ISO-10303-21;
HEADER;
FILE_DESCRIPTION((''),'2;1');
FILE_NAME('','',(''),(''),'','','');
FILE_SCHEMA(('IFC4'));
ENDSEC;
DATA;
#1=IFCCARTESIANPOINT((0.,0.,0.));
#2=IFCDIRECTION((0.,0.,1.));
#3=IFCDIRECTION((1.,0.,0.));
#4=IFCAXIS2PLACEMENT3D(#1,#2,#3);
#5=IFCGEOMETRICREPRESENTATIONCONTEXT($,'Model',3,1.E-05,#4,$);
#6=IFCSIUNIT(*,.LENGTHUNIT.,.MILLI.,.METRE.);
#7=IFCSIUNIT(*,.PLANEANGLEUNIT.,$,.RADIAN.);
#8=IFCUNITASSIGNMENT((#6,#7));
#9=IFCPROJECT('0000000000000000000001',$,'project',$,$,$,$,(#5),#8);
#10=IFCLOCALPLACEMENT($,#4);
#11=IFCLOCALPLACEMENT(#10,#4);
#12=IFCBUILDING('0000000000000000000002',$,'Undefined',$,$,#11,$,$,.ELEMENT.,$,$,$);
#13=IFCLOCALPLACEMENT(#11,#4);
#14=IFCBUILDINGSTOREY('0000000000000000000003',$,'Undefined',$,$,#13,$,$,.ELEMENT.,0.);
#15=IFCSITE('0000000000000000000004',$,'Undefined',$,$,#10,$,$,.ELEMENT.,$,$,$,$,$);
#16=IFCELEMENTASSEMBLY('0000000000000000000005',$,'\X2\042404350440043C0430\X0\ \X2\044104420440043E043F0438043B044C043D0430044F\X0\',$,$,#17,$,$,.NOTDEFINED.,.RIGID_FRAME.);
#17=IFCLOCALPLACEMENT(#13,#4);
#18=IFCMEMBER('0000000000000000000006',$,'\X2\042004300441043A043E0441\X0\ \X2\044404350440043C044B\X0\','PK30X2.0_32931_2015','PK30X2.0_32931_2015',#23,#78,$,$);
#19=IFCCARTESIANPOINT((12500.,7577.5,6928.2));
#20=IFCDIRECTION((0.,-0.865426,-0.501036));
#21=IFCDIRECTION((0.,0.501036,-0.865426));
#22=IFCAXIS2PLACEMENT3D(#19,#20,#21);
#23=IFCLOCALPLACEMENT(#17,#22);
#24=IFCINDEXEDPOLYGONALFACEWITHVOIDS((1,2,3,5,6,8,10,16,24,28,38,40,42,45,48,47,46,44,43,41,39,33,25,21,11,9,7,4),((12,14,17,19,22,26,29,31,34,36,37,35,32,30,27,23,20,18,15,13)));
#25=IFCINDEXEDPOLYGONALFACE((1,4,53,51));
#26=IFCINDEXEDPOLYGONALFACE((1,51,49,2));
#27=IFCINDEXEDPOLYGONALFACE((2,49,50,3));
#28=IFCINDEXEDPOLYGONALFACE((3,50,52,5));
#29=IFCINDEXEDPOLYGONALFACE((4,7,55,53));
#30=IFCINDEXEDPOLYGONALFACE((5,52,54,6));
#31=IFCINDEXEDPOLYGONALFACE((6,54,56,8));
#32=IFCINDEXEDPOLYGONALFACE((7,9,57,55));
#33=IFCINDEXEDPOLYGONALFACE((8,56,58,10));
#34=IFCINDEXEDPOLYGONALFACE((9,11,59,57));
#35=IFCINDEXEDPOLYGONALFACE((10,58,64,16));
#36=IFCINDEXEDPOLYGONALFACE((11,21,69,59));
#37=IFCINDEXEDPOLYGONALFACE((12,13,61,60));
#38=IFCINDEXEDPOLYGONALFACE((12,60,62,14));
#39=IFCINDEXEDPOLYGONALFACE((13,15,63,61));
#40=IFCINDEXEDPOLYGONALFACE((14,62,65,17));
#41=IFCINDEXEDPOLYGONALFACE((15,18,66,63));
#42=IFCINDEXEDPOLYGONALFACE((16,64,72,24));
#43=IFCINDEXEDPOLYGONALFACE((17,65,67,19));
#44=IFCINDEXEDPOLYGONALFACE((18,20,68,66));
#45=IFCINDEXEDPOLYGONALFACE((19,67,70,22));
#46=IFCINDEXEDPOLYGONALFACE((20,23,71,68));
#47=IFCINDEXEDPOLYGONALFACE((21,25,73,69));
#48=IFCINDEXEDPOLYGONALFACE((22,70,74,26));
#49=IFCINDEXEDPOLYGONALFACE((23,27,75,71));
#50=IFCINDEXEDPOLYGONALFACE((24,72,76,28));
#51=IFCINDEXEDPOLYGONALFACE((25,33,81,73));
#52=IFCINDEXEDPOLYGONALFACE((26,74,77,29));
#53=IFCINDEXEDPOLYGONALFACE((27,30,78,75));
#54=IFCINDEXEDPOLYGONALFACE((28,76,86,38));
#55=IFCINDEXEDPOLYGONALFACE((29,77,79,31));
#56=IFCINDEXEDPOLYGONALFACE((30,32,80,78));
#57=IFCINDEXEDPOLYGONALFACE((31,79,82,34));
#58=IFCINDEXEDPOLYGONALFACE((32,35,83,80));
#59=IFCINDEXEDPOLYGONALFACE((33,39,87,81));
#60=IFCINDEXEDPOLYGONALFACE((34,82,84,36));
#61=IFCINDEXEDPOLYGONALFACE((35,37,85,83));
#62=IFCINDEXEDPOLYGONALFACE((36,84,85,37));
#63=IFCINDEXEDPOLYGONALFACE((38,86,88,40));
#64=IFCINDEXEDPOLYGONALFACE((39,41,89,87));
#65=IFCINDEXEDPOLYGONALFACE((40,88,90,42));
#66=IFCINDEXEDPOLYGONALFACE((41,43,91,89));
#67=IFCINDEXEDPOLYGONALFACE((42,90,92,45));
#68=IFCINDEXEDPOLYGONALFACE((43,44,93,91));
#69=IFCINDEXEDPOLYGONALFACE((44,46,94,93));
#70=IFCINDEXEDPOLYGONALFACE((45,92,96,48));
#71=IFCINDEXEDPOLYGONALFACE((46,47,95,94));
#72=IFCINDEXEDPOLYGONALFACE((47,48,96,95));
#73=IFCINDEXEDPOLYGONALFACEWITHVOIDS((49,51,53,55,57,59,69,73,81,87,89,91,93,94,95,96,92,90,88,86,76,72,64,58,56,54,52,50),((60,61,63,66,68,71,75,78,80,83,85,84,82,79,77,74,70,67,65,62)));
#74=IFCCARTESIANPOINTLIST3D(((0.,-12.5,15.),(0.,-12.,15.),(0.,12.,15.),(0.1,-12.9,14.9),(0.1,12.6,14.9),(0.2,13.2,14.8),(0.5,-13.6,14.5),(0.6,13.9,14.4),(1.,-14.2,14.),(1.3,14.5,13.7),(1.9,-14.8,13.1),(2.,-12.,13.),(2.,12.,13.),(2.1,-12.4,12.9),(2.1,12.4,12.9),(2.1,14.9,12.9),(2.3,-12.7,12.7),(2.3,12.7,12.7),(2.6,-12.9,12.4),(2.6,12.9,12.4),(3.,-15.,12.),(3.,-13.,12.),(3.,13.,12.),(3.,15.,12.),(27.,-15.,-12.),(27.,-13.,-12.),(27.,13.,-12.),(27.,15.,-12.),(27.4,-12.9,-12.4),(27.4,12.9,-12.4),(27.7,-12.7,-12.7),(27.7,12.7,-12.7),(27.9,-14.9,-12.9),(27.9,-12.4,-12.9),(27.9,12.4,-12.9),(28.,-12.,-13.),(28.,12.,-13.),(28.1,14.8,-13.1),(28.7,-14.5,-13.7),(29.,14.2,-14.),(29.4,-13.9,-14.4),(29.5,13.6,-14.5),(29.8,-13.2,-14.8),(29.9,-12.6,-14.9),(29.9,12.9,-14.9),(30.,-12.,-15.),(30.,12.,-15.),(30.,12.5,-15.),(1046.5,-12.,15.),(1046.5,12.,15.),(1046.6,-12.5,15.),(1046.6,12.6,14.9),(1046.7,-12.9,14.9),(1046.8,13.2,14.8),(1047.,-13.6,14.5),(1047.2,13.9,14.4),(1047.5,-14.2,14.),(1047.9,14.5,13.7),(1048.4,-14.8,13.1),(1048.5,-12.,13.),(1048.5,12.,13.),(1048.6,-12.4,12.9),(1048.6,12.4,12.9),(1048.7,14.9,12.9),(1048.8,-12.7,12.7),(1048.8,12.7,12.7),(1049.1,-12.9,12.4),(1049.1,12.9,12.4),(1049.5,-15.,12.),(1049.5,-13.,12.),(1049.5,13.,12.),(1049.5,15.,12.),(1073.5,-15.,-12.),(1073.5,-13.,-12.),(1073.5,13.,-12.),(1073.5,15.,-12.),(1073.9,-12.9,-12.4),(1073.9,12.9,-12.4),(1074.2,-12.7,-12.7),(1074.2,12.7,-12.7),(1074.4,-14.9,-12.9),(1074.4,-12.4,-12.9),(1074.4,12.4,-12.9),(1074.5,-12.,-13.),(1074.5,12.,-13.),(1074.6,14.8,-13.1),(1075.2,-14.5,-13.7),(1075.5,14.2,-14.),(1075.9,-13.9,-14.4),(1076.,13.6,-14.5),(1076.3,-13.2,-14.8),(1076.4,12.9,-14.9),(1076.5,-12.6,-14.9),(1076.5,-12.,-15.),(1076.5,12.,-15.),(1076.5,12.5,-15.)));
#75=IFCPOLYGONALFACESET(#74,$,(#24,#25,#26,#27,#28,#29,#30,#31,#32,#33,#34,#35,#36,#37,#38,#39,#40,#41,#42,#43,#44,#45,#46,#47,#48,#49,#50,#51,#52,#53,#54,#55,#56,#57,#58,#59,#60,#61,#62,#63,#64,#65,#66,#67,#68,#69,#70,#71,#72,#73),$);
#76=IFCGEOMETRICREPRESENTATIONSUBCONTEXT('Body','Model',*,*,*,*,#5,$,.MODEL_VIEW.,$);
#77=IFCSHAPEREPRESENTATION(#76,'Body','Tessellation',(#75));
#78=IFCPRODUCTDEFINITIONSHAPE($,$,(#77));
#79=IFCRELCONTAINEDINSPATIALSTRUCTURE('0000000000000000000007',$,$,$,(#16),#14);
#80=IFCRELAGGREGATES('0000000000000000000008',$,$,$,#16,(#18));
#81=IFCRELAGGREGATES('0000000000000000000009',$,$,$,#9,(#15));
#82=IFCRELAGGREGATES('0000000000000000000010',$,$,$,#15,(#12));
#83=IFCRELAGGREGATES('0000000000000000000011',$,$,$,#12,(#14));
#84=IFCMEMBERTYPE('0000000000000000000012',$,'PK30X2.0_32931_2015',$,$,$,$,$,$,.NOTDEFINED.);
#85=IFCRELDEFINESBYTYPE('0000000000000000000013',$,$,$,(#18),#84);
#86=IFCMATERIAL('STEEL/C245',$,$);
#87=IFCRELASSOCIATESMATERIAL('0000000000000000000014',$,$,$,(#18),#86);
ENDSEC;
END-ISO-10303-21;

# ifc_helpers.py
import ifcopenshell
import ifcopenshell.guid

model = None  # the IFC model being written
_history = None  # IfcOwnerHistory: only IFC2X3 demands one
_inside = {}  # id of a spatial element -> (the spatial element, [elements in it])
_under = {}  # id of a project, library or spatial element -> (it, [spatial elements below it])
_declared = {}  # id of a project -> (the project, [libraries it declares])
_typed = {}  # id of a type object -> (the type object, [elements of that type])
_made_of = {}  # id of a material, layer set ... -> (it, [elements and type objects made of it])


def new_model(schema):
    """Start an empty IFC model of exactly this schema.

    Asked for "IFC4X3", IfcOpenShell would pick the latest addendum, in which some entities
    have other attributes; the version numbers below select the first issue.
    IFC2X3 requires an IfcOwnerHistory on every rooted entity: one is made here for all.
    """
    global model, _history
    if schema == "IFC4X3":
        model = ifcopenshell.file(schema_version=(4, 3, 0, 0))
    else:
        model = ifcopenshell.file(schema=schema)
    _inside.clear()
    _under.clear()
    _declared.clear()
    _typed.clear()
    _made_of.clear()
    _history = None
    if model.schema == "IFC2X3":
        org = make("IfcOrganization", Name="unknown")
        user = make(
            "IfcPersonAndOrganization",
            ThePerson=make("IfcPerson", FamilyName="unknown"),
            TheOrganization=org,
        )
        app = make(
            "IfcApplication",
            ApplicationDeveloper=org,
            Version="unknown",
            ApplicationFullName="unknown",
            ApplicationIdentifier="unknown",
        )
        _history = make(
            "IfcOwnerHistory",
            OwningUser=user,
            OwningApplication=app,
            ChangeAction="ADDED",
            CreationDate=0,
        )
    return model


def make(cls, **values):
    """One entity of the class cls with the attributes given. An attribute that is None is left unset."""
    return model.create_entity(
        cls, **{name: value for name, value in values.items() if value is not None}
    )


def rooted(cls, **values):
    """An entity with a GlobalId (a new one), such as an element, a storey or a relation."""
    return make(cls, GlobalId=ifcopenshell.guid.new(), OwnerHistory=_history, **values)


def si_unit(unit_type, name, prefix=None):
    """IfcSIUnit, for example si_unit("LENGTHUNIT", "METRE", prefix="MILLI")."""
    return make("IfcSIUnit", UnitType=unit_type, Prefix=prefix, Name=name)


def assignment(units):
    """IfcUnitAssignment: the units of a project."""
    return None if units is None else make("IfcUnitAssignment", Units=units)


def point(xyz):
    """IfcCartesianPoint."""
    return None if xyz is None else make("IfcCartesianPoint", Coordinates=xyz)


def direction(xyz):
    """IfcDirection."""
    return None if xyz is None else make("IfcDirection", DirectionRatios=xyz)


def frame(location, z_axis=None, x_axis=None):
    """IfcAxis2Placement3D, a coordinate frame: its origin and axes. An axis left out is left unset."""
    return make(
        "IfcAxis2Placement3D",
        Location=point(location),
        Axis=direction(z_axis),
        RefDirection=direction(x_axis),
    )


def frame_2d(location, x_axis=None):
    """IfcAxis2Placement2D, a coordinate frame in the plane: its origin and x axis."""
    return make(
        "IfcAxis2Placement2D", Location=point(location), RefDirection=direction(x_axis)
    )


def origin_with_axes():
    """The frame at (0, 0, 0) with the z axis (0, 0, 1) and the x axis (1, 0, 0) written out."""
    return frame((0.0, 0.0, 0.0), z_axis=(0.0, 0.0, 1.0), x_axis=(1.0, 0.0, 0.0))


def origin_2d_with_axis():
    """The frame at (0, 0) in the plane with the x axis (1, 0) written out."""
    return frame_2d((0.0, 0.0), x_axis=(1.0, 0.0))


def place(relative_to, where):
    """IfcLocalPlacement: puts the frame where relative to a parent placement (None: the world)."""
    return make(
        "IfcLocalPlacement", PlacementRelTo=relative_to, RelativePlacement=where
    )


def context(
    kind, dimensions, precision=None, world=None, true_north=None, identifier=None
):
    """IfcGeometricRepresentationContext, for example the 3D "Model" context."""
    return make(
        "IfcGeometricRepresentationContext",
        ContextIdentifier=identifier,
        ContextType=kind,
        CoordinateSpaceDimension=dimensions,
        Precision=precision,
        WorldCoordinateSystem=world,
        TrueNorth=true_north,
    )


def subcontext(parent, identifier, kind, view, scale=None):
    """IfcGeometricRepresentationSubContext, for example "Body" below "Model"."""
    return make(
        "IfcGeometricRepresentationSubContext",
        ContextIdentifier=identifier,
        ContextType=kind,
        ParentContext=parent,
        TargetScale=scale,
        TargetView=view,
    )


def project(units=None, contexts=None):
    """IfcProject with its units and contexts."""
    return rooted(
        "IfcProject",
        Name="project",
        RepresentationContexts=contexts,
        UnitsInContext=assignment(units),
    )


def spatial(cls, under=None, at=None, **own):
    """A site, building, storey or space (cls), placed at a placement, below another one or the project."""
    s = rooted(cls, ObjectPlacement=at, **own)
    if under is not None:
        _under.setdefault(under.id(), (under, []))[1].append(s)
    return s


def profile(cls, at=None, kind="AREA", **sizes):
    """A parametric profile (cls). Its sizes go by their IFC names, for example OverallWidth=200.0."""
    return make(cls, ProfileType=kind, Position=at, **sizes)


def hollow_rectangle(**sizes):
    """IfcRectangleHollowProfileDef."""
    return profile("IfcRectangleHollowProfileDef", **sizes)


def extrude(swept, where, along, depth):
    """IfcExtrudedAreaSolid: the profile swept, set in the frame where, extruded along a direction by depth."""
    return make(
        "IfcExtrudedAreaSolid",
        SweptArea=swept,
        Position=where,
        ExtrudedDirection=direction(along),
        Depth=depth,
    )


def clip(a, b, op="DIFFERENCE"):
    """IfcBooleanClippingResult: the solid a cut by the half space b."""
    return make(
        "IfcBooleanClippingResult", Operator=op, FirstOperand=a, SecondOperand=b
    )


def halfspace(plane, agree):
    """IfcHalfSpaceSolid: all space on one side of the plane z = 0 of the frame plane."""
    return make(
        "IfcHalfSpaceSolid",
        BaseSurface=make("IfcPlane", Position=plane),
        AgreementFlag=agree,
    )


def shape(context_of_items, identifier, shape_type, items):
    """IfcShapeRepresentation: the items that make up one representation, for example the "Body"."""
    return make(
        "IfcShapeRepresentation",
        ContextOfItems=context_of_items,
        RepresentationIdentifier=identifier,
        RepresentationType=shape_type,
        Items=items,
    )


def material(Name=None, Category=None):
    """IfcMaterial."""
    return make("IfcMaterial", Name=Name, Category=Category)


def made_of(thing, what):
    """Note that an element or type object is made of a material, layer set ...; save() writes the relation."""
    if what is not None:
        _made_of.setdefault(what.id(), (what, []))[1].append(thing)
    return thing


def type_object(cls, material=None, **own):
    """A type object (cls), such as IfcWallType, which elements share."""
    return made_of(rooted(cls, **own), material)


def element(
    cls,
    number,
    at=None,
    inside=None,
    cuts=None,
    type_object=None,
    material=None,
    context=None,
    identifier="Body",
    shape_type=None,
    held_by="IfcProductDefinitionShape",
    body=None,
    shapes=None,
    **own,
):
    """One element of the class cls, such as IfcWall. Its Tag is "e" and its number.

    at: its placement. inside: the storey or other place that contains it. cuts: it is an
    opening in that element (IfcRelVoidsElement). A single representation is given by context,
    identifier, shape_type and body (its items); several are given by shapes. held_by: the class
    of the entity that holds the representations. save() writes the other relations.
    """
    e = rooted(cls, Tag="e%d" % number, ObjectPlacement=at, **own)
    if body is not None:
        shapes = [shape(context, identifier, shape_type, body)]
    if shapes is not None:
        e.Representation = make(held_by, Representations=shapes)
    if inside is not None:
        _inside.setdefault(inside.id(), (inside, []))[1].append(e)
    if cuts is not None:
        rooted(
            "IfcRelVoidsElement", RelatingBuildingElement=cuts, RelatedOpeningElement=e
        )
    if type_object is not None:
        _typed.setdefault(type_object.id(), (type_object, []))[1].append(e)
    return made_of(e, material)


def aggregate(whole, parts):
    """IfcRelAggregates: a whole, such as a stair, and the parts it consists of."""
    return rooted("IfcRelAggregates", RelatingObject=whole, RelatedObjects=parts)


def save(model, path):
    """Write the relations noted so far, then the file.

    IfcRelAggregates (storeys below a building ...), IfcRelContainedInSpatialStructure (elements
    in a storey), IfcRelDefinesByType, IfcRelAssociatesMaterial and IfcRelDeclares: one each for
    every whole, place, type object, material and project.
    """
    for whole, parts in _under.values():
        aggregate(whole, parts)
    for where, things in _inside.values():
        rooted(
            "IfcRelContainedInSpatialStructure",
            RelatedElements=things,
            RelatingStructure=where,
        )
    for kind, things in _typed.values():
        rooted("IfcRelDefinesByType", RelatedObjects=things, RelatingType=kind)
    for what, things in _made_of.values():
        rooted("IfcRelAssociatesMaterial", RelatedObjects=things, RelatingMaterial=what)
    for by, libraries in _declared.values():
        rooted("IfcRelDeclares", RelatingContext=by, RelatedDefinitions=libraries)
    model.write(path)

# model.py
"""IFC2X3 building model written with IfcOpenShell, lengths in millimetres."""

from ifc_helpers import new_model, si_unit, frame, origin_with_axes, origin_2d_with_axis, place, context, subcontext, project, spatial, hollow_rectangle, extrude, clip, halfspace, material, type_object, element, aggregate, save


model = new_model("IFC2X3")

# Units and contexts
model_context = context("Model", 3, precision=1e-05, world=origin_with_axes())
body_context = subcontext(model_context, "Body", "Model", "MODEL_VIEW")
ifc_project = project(units=[si_unit("LENGTHUNIT", "METRE", prefix="MILLI"), si_unit("PLANEANGLEUNIT", "RADIAN")], contexts=[model_context])

# Site, building, storey
site_placement = place(None, origin_with_axes())
site = spatial("IfcSite", under=ifc_project, at=site_placement, Name="Undefined", CompositionType="ELEMENT")
building_placement = place(site_placement, origin_with_axes())
building = spatial("IfcBuilding", under=site, at=building_placement, Name="Undefined", CompositionType="ELEMENT")
storey_placement = place(building_placement, origin_with_axes())
storey = spatial("IfcBuildingStorey", under=building, at=storey_placement, Name="Undefined", CompositionType="ELEMENT", Elevation=0.0)

# Shared definitions
ifc_material_1 = material(Name="STEEL/C245")

# Shared definitions
member_type = type_object("IfcMemberType", Name="PK30X2.0_32931_2015", PredefinedType="NOTDEFINED")

# Element assembly, member
assembly_1_placement = place(storey_placement, origin_with_axes())
assembly_1 = element("IfcElementAssembly", 1, at=assembly_1_placement, inside=storey, Name="Ферма стропильная", AssemblyPlace="NOTDEFINED", PredefinedType="RIGID_FRAME")
member_1_placement = place(assembly_1_placement, frame((12500.0, 7577.5, 6928.2), z_axis=(0.0, -0.865426, -0.501036), x_axis=(0.0, 0.501036, -0.865426)))
member_1 = element("IfcMember", 2, at=member_1_placement, type_object=member_type, material=ifc_material_1, Name="Раскос фермы", Description="PK30X2.0_32931_2015", ObjectType="PK30X2.0_32931_2015", context=body_context, shape_type="Clipping", body=[
    clip(clip(extrude(hollow_rectangle(XDim=30.0, YDim=30.0, WallThickness=2.0, InnerFilletRadius=1.0, OuterFilletRadius=3.0, at=origin_2d_with_axis()), frame((1091.8, 0.0, 0.0), z_axis=(-1.0, 0.0, 0.0), x_axis=(0.0, -1.0, 0.0)), (0.0, 0.0, 1.0), 1107.1), halfspace(frame((1060.0, 0.0, 1.5), z_axis=(-0.707107, 0.0, -0.707107), x_axis=(0.707107, 0.0, -0.707107)), True)), halfspace(frame((34.5, 0.0, -19.5), z_axis=(-0.707107, 0.0, -0.707107), x_axis=(0.707107, 0.0, -0.707107)), False)),
])
aggregate(assembly_1, [member_1])

save(model, "model.ifc")
